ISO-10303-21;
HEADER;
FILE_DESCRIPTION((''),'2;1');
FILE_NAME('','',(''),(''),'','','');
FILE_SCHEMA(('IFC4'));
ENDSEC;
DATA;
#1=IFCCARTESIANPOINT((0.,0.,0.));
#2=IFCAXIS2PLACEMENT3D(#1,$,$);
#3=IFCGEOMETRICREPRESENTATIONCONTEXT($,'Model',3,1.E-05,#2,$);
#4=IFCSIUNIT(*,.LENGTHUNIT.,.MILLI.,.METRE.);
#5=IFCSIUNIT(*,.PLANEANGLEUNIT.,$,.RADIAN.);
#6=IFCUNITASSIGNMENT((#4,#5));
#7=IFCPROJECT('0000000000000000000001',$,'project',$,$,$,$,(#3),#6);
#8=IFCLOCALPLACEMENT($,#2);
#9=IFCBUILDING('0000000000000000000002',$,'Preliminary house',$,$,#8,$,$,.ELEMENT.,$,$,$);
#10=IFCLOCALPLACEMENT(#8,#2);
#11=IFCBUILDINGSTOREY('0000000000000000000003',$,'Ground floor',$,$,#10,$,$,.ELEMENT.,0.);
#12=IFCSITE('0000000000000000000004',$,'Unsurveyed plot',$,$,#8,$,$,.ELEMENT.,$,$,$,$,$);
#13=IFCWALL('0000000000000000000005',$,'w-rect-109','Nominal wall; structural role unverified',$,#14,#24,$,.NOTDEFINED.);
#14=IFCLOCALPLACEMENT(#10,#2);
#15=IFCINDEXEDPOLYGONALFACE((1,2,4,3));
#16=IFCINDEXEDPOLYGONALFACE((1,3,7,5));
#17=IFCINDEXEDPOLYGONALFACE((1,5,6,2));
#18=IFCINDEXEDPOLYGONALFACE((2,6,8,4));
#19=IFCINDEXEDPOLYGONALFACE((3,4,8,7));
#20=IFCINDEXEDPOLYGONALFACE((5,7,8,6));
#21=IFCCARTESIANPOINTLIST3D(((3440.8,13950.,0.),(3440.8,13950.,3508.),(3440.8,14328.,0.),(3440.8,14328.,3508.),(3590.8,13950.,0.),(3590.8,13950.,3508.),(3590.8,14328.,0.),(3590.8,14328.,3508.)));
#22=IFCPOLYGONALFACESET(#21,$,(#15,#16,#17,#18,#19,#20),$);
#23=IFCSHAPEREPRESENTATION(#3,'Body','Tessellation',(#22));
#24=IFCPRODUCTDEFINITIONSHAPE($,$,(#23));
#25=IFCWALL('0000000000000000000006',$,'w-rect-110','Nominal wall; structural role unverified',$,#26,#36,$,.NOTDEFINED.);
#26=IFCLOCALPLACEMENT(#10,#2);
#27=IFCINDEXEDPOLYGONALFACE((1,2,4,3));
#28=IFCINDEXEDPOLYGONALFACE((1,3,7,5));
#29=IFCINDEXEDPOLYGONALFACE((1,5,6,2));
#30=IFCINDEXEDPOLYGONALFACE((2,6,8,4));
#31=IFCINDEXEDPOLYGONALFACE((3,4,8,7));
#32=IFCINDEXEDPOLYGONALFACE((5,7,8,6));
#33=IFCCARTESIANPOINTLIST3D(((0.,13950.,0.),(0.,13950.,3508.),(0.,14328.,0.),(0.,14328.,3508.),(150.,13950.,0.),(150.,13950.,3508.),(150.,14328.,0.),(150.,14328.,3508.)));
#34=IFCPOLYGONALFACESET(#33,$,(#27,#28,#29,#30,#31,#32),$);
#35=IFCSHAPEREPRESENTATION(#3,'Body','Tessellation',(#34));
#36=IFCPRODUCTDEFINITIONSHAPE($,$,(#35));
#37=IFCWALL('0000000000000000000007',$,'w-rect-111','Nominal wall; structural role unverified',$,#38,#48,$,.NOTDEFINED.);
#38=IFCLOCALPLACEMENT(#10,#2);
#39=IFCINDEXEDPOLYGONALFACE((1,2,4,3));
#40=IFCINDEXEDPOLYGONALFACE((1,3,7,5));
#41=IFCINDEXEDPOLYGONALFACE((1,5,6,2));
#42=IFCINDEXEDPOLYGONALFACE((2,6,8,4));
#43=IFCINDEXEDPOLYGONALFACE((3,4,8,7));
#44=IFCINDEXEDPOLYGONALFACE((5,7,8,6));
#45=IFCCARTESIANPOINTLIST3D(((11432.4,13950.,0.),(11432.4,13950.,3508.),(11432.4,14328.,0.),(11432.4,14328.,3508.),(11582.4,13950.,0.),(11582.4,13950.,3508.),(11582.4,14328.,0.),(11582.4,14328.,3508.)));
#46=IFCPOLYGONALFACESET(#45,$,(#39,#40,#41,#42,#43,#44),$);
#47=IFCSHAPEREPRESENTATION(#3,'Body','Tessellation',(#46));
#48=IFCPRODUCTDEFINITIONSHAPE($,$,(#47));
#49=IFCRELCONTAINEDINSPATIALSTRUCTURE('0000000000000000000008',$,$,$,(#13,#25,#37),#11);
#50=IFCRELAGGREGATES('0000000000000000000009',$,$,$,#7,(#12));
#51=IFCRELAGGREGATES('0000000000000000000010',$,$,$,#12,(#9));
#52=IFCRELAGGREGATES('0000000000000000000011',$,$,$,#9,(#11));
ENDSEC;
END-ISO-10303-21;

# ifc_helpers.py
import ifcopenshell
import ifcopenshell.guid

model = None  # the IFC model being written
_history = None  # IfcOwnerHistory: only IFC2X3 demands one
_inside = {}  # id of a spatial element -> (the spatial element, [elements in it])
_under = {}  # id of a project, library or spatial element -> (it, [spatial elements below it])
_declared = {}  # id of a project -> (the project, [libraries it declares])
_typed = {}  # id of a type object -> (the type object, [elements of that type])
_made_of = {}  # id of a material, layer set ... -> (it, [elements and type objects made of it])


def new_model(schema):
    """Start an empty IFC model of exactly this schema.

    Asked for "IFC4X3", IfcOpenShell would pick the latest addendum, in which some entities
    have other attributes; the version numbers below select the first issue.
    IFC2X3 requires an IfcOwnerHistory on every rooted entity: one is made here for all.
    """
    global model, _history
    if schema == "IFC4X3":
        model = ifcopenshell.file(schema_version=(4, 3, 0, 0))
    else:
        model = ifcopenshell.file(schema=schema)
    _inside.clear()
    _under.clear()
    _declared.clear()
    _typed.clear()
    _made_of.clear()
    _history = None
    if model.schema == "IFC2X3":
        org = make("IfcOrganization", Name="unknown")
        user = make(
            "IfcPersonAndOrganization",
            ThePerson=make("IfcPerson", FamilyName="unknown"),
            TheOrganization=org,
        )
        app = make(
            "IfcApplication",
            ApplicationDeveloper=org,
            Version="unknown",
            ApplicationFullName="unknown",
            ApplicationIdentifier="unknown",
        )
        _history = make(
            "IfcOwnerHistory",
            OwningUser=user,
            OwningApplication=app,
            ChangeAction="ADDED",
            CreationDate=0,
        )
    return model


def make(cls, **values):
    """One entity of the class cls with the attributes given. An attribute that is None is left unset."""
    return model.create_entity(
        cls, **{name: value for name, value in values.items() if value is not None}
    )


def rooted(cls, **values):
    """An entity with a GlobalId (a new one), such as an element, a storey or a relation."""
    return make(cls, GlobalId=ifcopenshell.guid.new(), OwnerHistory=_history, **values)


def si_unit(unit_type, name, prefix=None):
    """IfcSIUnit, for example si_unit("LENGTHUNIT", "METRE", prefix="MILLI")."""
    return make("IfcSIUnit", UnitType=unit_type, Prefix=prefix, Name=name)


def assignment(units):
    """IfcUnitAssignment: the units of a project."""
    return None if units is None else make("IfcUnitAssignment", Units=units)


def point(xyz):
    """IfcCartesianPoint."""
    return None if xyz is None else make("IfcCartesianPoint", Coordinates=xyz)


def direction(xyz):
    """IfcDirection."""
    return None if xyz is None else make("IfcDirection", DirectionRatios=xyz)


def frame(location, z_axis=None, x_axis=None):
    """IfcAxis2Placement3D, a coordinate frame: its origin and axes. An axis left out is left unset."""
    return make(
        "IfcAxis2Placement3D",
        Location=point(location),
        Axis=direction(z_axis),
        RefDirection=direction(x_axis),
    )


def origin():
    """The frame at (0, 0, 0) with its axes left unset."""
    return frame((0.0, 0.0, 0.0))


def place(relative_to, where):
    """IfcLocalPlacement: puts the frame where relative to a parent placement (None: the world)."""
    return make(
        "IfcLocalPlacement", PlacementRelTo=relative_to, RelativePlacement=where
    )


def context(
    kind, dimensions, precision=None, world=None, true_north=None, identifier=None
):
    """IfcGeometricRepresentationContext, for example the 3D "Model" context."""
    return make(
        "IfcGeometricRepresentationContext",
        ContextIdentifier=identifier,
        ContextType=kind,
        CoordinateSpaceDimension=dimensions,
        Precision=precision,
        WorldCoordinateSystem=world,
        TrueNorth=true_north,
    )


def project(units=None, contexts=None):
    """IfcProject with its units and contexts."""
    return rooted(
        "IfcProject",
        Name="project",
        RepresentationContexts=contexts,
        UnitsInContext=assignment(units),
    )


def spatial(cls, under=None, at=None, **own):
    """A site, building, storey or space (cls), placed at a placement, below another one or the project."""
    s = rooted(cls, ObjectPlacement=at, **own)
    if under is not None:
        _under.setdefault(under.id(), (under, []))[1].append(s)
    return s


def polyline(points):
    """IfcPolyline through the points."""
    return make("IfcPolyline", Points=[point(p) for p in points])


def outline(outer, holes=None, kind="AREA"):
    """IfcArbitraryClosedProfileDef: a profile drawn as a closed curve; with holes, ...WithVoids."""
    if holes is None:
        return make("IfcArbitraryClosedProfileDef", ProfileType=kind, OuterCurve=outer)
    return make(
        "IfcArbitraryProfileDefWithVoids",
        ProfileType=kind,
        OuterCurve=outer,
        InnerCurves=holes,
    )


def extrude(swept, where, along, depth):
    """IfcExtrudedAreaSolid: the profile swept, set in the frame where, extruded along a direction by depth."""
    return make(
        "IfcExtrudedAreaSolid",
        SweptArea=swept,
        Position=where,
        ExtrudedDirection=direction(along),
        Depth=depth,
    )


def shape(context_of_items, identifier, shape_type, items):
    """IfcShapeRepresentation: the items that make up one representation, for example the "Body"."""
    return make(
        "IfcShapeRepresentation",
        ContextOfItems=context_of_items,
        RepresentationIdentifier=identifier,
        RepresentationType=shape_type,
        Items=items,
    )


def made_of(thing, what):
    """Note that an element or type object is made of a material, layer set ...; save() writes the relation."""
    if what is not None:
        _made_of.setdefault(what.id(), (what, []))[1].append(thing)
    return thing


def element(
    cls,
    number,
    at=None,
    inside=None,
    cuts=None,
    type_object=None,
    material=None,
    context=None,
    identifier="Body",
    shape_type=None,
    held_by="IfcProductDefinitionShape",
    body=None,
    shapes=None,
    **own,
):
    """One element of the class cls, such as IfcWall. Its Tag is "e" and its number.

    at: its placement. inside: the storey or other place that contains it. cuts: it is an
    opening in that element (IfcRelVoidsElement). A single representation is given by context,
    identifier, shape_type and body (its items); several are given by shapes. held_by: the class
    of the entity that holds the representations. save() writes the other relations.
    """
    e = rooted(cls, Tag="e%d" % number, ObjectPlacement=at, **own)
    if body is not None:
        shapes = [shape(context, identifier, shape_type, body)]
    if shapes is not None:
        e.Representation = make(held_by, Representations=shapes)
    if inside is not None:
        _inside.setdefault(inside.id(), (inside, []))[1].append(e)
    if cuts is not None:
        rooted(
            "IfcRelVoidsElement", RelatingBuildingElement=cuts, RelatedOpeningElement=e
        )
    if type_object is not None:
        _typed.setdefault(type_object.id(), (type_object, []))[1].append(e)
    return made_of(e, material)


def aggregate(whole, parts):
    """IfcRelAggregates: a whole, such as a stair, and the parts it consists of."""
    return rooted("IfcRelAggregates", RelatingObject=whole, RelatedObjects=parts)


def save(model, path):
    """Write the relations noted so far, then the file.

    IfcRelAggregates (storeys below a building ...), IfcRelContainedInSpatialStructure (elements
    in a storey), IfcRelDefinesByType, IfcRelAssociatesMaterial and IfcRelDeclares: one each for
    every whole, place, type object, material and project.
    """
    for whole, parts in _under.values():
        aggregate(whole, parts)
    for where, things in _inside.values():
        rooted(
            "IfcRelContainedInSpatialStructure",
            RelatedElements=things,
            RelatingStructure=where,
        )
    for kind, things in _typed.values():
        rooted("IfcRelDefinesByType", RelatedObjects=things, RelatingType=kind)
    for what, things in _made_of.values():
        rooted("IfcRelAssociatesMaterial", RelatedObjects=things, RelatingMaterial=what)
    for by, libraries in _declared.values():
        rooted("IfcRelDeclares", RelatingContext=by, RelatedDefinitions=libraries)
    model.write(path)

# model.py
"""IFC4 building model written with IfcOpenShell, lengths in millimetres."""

from ifc_helpers import new_model, si_unit, origin, place, context, project, spatial, polyline, outline, extrude, element, save


model = new_model("IFC4")

# Units and contexts
model_context = context("Model", 3, precision=1e-05, world=origin())
ifc_project = project(units=[si_unit("LENGTHUNIT", "METRE", prefix="MILLI"), si_unit("PLANEANGLEUNIT", "RADIAN")], contexts=[model_context])

# Site, building, storey
placement_1 = place(None, origin())
site = spatial("IfcSite", under=ifc_project, at=placement_1, Name="Unsurveyed plot", CompositionType="ELEMENT")
building = spatial("IfcBuilding", under=site, at=placement_1, Name="Preliminary house", CompositionType="ELEMENT")
placement_2 = place(placement_1, origin())
storey = spatial("IfcBuildingStorey", under=building, at=placement_2, Name="Ground floor", CompositionType="ELEMENT", Elevation=0.0)

# Walls
element("IfcWall", 1, at=placement_2, inside=storey, Name="w-rect-109", Description="Nominal wall; structural role unverified", PredefinedType="NOTDEFINED", context=model_context, shape_type="SweptSolid", body=[
    extrude(outline(polyline([(3440.8, 13950.0), (3590.8, 13950.0), (3590.8, 14328.0), (3440.8, 14328.0), (3440.8, 13950.0)])), origin(), (0.0, 0.0, 1.0), 3508.0),
])
element("IfcWall", 2, at=placement_2, inside=storey, Name="w-rect-110", Description="Nominal wall; structural role unverified", PredefinedType="NOTDEFINED", context=model_context, shape_type="SweptSolid", body=[
    extrude(outline(polyline([(0.0, 13950.0), (150.0, 13950.0), (150.0, 14328.0), (0.0, 14328.0), (0.0, 13950.0)])), origin(), (0.0, 0.0, 1.0), 3508.0),
])
element("IfcWall", 3, at=placement_2, inside=storey, Name="w-rect-111", Description="Nominal wall; structural role unverified", PredefinedType="NOTDEFINED", context=model_context, shape_type="SweptSolid", body=[
    extrude(outline(polyline([(11432.4, 13950.0), (11582.4, 13950.0), (11582.4, 14328.0), (11432.4, 14328.0), (11432.4, 13950.0)])), origin(), (0.0, 0.0, 1.0), 3508.0),
])

save(model, "model.ifc")
